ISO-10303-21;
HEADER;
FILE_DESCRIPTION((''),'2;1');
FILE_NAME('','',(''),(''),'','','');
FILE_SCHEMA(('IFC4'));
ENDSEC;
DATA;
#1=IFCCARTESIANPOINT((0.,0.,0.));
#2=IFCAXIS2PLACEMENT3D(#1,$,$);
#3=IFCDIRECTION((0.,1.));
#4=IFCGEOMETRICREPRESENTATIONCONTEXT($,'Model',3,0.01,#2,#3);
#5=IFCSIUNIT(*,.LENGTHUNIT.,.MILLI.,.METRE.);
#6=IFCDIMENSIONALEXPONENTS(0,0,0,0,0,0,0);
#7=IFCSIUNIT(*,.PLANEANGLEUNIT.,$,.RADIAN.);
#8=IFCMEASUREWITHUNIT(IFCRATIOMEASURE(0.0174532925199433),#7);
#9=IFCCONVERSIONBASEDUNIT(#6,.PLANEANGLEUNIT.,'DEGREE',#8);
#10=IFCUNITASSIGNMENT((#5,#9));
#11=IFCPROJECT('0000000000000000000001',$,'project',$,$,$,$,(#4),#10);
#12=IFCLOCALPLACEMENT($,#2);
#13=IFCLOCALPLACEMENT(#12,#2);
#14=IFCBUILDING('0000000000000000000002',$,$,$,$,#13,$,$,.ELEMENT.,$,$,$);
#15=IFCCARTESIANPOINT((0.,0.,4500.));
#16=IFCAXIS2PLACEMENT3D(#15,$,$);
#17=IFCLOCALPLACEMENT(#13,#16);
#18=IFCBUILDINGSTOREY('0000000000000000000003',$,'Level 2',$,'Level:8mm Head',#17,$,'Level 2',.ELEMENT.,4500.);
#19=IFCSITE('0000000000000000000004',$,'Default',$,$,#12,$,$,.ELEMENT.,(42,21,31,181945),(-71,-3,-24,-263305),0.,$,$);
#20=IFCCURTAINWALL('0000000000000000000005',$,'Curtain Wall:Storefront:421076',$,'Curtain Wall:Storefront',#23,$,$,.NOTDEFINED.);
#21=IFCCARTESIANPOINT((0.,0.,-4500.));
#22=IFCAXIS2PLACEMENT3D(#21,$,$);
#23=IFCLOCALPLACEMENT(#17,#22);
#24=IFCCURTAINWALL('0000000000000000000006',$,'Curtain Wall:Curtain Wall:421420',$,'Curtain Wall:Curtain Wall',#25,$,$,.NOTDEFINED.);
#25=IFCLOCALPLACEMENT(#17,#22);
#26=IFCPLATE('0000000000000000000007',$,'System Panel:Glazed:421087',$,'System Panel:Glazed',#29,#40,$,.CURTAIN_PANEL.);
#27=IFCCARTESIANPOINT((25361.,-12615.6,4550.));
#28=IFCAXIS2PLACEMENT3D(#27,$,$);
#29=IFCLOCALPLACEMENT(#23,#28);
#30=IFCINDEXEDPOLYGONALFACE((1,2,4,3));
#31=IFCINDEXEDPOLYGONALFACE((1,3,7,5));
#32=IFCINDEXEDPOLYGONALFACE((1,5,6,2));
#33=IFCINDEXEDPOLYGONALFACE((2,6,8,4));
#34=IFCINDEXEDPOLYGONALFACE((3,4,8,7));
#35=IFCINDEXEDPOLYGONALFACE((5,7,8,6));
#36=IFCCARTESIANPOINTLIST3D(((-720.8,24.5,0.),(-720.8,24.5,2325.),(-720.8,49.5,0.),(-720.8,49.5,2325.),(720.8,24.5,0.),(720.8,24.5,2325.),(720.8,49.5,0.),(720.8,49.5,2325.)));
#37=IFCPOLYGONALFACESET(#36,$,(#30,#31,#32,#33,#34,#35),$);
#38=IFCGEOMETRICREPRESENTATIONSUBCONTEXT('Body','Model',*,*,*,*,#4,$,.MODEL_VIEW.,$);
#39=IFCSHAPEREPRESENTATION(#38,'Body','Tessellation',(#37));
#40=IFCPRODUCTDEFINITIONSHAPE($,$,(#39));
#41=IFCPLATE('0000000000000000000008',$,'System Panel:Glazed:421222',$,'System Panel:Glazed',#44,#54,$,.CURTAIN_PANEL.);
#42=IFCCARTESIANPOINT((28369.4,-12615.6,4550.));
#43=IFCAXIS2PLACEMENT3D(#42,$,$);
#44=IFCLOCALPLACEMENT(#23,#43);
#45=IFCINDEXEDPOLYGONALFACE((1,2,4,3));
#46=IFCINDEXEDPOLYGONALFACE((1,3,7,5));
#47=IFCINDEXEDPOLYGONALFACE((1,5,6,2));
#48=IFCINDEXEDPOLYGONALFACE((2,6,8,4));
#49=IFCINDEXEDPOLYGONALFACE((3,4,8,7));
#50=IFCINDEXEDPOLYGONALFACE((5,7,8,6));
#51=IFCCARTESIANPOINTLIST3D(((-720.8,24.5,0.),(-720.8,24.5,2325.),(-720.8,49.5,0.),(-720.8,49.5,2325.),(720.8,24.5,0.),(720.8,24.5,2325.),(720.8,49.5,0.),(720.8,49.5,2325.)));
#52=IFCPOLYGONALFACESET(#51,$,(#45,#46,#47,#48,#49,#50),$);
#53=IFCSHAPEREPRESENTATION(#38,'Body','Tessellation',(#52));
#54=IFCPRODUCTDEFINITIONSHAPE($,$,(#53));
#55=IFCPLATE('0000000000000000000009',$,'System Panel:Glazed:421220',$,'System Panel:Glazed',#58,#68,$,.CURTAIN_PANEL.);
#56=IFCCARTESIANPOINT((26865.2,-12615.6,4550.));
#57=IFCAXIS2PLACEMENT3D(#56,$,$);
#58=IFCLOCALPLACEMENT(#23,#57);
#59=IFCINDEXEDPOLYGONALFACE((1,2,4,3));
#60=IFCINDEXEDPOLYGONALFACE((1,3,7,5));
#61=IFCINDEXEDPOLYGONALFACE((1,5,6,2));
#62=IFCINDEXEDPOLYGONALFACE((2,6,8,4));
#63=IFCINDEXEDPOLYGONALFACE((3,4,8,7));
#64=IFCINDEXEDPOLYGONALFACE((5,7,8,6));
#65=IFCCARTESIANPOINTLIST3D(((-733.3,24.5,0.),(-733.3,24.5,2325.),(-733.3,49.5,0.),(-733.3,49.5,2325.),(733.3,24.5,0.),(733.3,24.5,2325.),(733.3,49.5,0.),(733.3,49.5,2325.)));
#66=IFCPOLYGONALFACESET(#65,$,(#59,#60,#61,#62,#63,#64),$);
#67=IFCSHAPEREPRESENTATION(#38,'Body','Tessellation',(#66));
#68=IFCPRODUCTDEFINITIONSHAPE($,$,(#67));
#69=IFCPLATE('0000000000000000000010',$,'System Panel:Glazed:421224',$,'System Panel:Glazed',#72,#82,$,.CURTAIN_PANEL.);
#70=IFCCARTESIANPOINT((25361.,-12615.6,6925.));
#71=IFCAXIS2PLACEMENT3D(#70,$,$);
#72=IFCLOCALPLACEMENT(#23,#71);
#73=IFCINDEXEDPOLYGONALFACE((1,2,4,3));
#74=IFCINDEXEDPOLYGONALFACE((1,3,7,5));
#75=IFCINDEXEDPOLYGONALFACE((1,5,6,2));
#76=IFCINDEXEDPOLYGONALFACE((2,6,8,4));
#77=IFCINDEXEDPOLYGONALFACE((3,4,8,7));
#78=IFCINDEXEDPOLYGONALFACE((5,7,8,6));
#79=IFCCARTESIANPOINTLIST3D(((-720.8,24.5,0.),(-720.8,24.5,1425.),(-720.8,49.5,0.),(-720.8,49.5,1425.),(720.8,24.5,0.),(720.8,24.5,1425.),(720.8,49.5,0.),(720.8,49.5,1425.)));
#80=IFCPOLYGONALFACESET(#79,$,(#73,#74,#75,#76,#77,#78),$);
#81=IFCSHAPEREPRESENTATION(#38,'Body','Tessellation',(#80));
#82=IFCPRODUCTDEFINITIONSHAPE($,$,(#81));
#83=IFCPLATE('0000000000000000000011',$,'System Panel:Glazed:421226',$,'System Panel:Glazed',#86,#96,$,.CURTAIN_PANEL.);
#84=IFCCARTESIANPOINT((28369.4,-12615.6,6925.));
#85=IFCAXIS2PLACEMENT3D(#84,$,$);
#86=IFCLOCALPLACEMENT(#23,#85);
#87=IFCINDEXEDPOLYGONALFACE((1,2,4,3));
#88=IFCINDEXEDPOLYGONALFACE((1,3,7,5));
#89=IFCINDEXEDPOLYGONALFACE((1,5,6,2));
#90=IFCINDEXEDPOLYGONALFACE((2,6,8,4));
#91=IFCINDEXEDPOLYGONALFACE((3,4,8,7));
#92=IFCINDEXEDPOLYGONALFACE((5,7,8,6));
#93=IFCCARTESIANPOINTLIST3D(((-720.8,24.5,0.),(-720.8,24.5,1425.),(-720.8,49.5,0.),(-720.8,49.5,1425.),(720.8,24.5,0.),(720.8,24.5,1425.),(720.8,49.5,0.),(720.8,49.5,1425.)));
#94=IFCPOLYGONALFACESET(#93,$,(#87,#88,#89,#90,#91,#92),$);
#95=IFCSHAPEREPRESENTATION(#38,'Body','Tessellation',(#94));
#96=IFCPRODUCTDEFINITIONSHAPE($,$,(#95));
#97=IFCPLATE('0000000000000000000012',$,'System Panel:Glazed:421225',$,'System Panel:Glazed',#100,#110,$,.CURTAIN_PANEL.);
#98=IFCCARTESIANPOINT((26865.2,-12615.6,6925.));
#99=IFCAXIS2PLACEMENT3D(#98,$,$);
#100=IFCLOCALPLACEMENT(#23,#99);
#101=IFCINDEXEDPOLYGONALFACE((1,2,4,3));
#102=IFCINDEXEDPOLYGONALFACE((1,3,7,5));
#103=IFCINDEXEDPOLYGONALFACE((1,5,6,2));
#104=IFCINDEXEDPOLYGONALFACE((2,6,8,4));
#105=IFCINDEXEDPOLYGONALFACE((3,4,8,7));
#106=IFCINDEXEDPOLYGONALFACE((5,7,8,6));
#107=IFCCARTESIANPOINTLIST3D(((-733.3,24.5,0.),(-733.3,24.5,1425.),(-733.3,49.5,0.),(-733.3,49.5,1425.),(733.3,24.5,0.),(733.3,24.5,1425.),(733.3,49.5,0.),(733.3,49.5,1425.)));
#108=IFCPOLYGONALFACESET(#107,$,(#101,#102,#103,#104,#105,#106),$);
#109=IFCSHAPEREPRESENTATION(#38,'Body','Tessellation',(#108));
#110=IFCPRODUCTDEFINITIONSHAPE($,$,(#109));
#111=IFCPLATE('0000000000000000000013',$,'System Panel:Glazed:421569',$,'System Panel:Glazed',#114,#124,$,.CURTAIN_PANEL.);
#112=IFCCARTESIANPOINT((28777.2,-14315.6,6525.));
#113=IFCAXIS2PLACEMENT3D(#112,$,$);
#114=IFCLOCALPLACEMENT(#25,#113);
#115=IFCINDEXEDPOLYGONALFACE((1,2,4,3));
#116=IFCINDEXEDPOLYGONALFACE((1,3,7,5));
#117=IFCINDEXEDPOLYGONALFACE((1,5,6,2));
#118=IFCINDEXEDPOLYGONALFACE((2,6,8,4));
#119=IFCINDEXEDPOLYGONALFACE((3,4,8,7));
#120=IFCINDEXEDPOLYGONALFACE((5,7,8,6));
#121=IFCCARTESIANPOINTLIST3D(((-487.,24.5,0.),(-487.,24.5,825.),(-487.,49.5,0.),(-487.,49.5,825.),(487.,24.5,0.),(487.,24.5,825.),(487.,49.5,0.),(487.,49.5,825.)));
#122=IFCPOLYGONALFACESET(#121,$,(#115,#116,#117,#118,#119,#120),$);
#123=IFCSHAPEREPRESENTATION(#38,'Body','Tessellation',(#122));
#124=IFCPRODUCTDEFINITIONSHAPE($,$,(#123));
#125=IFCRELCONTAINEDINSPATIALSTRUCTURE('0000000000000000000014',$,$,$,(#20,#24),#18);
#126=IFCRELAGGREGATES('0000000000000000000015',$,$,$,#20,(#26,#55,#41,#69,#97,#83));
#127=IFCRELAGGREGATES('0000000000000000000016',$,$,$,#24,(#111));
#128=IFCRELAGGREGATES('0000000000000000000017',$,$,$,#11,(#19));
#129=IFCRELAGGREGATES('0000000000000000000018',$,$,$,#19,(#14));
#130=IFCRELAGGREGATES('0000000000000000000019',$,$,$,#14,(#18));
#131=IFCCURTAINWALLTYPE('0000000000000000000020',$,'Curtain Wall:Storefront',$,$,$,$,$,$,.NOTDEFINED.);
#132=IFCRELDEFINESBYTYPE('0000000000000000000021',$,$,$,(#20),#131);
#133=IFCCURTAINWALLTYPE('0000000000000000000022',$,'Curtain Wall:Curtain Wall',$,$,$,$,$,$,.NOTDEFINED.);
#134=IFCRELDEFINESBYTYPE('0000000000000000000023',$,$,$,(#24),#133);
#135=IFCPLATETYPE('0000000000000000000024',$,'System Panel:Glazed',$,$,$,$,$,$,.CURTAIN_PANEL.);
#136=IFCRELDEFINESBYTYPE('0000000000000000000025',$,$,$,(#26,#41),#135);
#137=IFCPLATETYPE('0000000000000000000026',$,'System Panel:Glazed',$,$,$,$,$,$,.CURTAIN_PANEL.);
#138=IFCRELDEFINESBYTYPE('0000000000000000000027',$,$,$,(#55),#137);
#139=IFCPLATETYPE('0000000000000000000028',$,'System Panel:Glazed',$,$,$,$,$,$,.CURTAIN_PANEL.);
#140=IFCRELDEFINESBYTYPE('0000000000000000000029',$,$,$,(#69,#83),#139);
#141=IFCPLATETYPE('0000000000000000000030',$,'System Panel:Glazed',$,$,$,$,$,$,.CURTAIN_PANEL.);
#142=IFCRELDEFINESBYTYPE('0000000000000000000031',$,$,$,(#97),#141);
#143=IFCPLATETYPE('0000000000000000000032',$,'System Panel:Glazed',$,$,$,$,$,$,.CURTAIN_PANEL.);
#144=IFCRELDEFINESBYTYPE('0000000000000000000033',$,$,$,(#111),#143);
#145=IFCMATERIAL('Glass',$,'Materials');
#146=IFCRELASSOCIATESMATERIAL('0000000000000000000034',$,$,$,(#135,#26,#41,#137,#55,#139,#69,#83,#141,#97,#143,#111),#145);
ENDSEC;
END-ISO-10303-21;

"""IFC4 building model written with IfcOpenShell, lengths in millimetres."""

from ifc_helpers import new_model, entity, si_unit, converted_unit, direction, frame, origin, place, context, subcontext, project, spatial, indexed_curve, outline, extrude, shape, source, transform, mapped, material, type_object, type_shapes, element, aggregate, save


model = new_model("IFC4")

# Units and contexts
model_context = context("Model", 3, precision=0.01, world=origin(), true_north=direction((0.0, 1.0)))
body_context = subcontext(model_context, "Body", "Model", "MODEL_VIEW")
footprint_context = subcontext(model_context, "FootPrint", "Model", "MODEL_VIEW")
ifc_project = project(units=[si_unit("LENGTHUNIT", "METRE", prefix="MILLI"), converted_unit("PLANEANGLEUNIT", "DEGREE", entity("IfcRatioMeasure", 0.0174532925199433), si_unit("PLANEANGLEUNIT", "RADIAN"), dimensions=[0, 0, 0, 0, 0, 0, 0])], contexts=[model_context])

# Site, building, storey
site_placement = place(None, origin())
site = spatial("IfcSite", under=ifc_project, at=site_placement, Name="Default", CompositionType="ELEMENT", RefLatitude=(42, 21, 31, 181945), RefLongitude=(-71, -3, -24, -263305), RefElevation=0.0)
building_placement = place(site_placement, origin())
building = spatial("IfcBuilding", under=site, at=building_placement, CompositionType="ELEMENT")
storey_placement = place(building_placement, frame((0.0, 0.0, 4500.0)))
storey = spatial("IfcBuildingStorey", under=building, at=storey_placement, Name="Level 2", ObjectType="Level:8mm Head", LongName="Level 2", CompositionType="ELEMENT", Elevation=4500.0)

# Curtain walls
curtain_wall_type_1 = type_object("IfcCurtainWallType", Name="Curtain Wall:Storefront", PredefinedType="NOTDEFINED")
curtain_wall_1_placement = place(storey_placement, frame((0.0, 0.0, -4500.0)))
curtain_wall_1 = element("IfcCurtainWall", 1, at=curtain_wall_1_placement, inside=storey, type_object=curtain_wall_type_1, Name="Curtain Wall:Storefront:421076", ObjectType="Curtain Wall:Storefront", PredefinedType="NOTDEFINED")
curtain_wall_type_2 = type_object("IfcCurtainWallType", Name="Curtain Wall:Curtain Wall", PredefinedType="NOTDEFINED")
curtain_wall_2_placement = place(storey_placement, frame((0.0, 0.0, -4500.0)))
curtain_wall_2 = element("IfcCurtainWall", 2, at=curtain_wall_2_placement, inside=storey, type_object=curtain_wall_type_2, Name="Curtain Wall:Curtain Wall:421420", ObjectType="Curtain Wall:Curtain Wall", PredefinedType="NOTDEFINED")

# Plates
ifc_material_1 = material(Name="Glass", Category="Materials")
plate_type_1 = type_object("IfcPlateType", Name="System Panel:Glazed", PredefinedType="CURTAIN_PANEL", material=ifc_material_1)
shared_shape_1 = source(origin(), body_context, "Body", "SweptSolid", [
    extrude(outline(indexed_curve([(-12.5, -720.8), (12.5, -720.8), (12.5, 720.8), (-12.5, 720.8), (-12.5, -720.8)], self_intersect=False)), frame((0.0, 37.0, 0.0), z_axis=(0.0, 0.0, 1.0), x_axis=(0.0, 1.0, 0.0)), (0.0, 0.0, 1.0), 2325.0),
])
shared_shape_2 = source(origin(), footprint_context, "FootPrint", "Curve2D", [
    entity("IfcIndexedPolyCurve", entity("IfcCartesianPointList2D", [[720.8, 24.5], [720.8, 49.5], [-720.8, 49.5], [-720.8, 24.5], [720.8, 24.5]]), None, False),
])
type_shapes(plate_type_1, [shared_shape_1, shared_shape_2])
plate_1_placement = place(curtain_wall_1_placement, frame((25361.0, -12615.6, 4550.0)))
plate_1 = element("IfcPlate", 3, at=plate_1_placement, type_object=plate_type_1, material=ifc_material_1, Name="System Panel:Glazed:421087", ObjectType="System Panel:Glazed", PredefinedType="CURTAIN_PANEL", shapes=[
    shape(body_context, "Body", "MappedRepresentation", [mapped(shared_shape_1, transform((0.0, 0.0, 0.0), scale=1.0))]),
    shape(body_context, "Body", "MappedRepresentation", [mapped(shared_shape_2, transform((0.0, 0.0, 0.0), scale=1.0))]),
])
plate_2_placement = place(curtain_wall_1_placement, frame((28369.4, -12615.6, 4550.0)))
plate_2 = element("IfcPlate", 4, at=plate_2_placement, type_object=plate_type_1, material=ifc_material_1, Name="System Panel:Glazed:421222", ObjectType="System Panel:Glazed", PredefinedType="CURTAIN_PANEL", shapes=[
    shape(body_context, "Body", "MappedRepresentation", [mapped(shared_shape_1, transform((0.0, 0.0, 0.0), scale=1.0))]),
    shape(body_context, "Body", "MappedRepresentation", [mapped(shared_shape_2, transform((0.0, 0.0, 0.0), scale=1.0))]),
])
plate_type_2 = type_object("IfcPlateType", Name="System Panel:Glazed", PredefinedType="CURTAIN_PANEL", material=ifc_material_1)
shared_shape_3 = source(origin(), body_context, "Body", "SweptSolid", [
    extrude(outline(indexed_curve([(-12.5, -733.3), (12.5, -733.3), (12.5, 733.3), (-12.5, 733.3), (-12.5, -733.3)], self_intersect=False)), frame((0.0, 37.0, 0.0), z_axis=(0.0, 0.0, 1.0), x_axis=(0.0, 1.0, 0.0)), (0.0, 0.0, 1.0), 2325.0),
])
shared_shape_4 = source(origin(), footprint_context, "FootPrint", "Curve2D", [
    entity("IfcIndexedPolyCurve", entity("IfcCartesianPointList2D", [[733.3, 24.5], [733.3, 49.5], [-733.3, 49.5], [-733.3, 24.5], [733.3, 24.5]]), None, False),
])
type_shapes(plate_type_2, [shared_shape_3, shared_shape_4])
plate_3_placement = place(curtain_wall_1_placement, frame((26865.2, -12615.6, 4550.0)))
plate_3 = element("IfcPlate", 5, at=plate_3_placement, type_object=plate_type_2, material=ifc_material_1, Name="System Panel:Glazed:421220", ObjectType="System Panel:Glazed", PredefinedType="CURTAIN_PANEL", shapes=[
    shape(body_context, "Body", "MappedRepresentation", [mapped(shared_shape_3, transform((0.0, 0.0, 0.0), scale=1.0))]),
    shape(body_context, "Body", "MappedRepresentation", [mapped(shared_shape_4, transform((0.0, 0.0, 0.0), scale=1.0))]),
])
plate_type_3 = type_object("IfcPlateType", Name="System Panel:Glazed", PredefinedType="CURTAIN_PANEL", material=ifc_material_1)
shared_shape_5 = source(origin(), body_context, "Body", "SweptSolid", [
    extrude(outline(indexed_curve([(-12.5, -720.8), (12.5, -720.8), (12.5, 720.8), (-12.5, 720.8), (-12.5, -720.8)], self_intersect=False)), frame((0.0, 37.0, 0.0), z_axis=(0.0, 0.0, 1.0), x_axis=(0.0, 1.0, 0.0)), (0.0, 0.0, 1.0), 1425.0),
])
shared_shape_6 = source(origin(), footprint_context, "FootPrint", "Curve2D", [
    entity("IfcIndexedPolyCurve", entity("IfcCartesianPointList2D", [[720.8, 24.5], [720.8, 49.5], [-720.8, 49.5], [-720.8, 24.5], [720.8, 24.5]]), None, False),
])
type_shapes(plate_type_3, [shared_shape_5, shared_shape_6])
plate_4_placement = place(curtain_wall_1_placement, frame((25361.0, -12615.6, 6925.0)))
plate_4 = element("IfcPlate", 6, at=plate_4_placement, type_object=plate_type_3, material=ifc_material_1, Name="System Panel:Glazed:421224", ObjectType="System Panel:Glazed", PredefinedType="CURTAIN_PANEL", shapes=[
    shape(body_context, "Body", "MappedRepresentation", [mapped(shared_shape_5, transform((0.0, 0.0, 0.0), scale=1.0))]),
    shape(body_context, "Body", "MappedRepresentation", [mapped(shared_shape_6, transform((0.0, 0.0, 0.0), scale=1.0))]),
])
plate_5_placement = place(curtain_wall_1_placement, frame((28369.4, -12615.6, 6925.0)))
plate_5 = element("IfcPlate", 7, at=plate_5_placement, type_object=plate_type_3, material=ifc_material_1, Name="System Panel:Glazed:421226", ObjectType="System Panel:Glazed", PredefinedType="CURTAIN_PANEL", shapes=[
    shape(body_context, "Body", "MappedRepresentation", [mapped(shared_shape_5, transform((0.0, 0.0, 0.0), scale=1.0))]),
    shape(body_context, "Body", "MappedRepresentation", [mapped(shared_shape_6, transform((0.0, 0.0, 0.0), scale=1.0))]),
])
plate_type_4 = type_object("IfcPlateType", Name="System Panel:Glazed", PredefinedType="CURTAIN_PANEL", material=ifc_material_1)
shared_shape_7 = source(origin(), body_context, "Body", "SweptSolid", [
    extrude(outline(indexed_curve([(-12.5, -733.3), (12.5, -733.3), (12.5, 733.3), (-12.5, 733.3), (-12.5, -733.3)], self_intersect=False)), frame((0.0, 37.0, 0.0), z_axis=(0.0, 0.0, 1.0), x_axis=(0.0, 1.0, 0.0)), (0.0, 0.0, 1.0), 1425.0),
])
shared_shape_8 = source(origin(), footprint_context, "FootPrint", "Curve2D", [
    entity("IfcIndexedPolyCurve", entity("IfcCartesianPointList2D", [[733.3, 24.5], [733.3, 49.5], [-733.3, 49.5], [-733.3, 24.5], [733.3, 24.5]]), None, False),
])
type_shapes(plate_type_4, [shared_shape_7, shared_shape_8])
plate_6_placement = place(curtain_wall_1_placement, frame((26865.2, -12615.6, 6925.0)))
plate_6 = element("IfcPlate", 8, at=plate_6_placement, type_object=plate_type_4, material=ifc_material_1, Name="System Panel:Glazed:421225", ObjectType="System Panel:Glazed", PredefinedType="CURTAIN_PANEL", shapes=[
    shape(body_context, "Body", "MappedRepresentation", [mapped(shared_shape_7, transform((0.0, 0.0, 0.0), scale=1.0))]),
    shape(body_context, "Body", "MappedRepresentation", [mapped(shared_shape_8, transform((0.0, 0.0, 0.0), scale=1.0))]),
])
aggregate(curtain_wall_1, [plate_1, plate_3, plate_2, plate_4, plate_6, plate_5])
plate_type_5 = type_object("IfcPlateType", Name="System Panel:Glazed", PredefinedType="CURTAIN_PANEL", material=ifc_material_1)
shared_shape_9 = source(origin(), body_context, "Body", "SweptSolid", [
    extrude(outline(indexed_curve([(-12.5, -487.0), (12.5, -487.0), (12.5, 487.0), (-12.5, 487.0), (-12.5, -487.0)], self_intersect=False)), frame((0.0, 37.0, 0.0), z_axis=(0.0, 0.0, 1.0), x_axis=(0.0, 1.0, 0.0)), (0.0, 0.0, 1.0), 825.0),
])
shared_shape_10 = source(origin(), footprint_context, "FootPrint", "Curve2D", [
    entity("IfcIndexedPolyCurve", entity("IfcCartesianPointList2D", [[487.0, 24.5], [487.0, 49.5], [-487.0, 49.5], [-487.0, 24.5], [487.0, 24.5]]), None, False),
])
type_shapes(plate_type_5, [shared_shape_9, shared_shape_10])
plate_7_placement = place(curtain_wall_2_placement, frame((28777.2, -14315.6, 6525.0)))
plate_7 = element("IfcPlate", 9, at=plate_7_placement, type_object=plate_type_5, material=ifc_material_1, Name="System Panel:Glazed:421569", ObjectType="System Panel:Glazed", PredefinedType="CURTAIN_PANEL", shapes=[
    shape(body_context, "Body", "MappedRepresentation", [mapped(shared_shape_9, transform((0.0, 0.0, 0.0), scale=1.0))]),
    shape(body_context, "Body", "MappedRepresentation", [mapped(shared_shape_10, transform((0.0, 0.0, 0.0), scale=1.0))]),
])

aggregate(curtain_wall_2, [plate_7])

save(model, "model.ifc")
